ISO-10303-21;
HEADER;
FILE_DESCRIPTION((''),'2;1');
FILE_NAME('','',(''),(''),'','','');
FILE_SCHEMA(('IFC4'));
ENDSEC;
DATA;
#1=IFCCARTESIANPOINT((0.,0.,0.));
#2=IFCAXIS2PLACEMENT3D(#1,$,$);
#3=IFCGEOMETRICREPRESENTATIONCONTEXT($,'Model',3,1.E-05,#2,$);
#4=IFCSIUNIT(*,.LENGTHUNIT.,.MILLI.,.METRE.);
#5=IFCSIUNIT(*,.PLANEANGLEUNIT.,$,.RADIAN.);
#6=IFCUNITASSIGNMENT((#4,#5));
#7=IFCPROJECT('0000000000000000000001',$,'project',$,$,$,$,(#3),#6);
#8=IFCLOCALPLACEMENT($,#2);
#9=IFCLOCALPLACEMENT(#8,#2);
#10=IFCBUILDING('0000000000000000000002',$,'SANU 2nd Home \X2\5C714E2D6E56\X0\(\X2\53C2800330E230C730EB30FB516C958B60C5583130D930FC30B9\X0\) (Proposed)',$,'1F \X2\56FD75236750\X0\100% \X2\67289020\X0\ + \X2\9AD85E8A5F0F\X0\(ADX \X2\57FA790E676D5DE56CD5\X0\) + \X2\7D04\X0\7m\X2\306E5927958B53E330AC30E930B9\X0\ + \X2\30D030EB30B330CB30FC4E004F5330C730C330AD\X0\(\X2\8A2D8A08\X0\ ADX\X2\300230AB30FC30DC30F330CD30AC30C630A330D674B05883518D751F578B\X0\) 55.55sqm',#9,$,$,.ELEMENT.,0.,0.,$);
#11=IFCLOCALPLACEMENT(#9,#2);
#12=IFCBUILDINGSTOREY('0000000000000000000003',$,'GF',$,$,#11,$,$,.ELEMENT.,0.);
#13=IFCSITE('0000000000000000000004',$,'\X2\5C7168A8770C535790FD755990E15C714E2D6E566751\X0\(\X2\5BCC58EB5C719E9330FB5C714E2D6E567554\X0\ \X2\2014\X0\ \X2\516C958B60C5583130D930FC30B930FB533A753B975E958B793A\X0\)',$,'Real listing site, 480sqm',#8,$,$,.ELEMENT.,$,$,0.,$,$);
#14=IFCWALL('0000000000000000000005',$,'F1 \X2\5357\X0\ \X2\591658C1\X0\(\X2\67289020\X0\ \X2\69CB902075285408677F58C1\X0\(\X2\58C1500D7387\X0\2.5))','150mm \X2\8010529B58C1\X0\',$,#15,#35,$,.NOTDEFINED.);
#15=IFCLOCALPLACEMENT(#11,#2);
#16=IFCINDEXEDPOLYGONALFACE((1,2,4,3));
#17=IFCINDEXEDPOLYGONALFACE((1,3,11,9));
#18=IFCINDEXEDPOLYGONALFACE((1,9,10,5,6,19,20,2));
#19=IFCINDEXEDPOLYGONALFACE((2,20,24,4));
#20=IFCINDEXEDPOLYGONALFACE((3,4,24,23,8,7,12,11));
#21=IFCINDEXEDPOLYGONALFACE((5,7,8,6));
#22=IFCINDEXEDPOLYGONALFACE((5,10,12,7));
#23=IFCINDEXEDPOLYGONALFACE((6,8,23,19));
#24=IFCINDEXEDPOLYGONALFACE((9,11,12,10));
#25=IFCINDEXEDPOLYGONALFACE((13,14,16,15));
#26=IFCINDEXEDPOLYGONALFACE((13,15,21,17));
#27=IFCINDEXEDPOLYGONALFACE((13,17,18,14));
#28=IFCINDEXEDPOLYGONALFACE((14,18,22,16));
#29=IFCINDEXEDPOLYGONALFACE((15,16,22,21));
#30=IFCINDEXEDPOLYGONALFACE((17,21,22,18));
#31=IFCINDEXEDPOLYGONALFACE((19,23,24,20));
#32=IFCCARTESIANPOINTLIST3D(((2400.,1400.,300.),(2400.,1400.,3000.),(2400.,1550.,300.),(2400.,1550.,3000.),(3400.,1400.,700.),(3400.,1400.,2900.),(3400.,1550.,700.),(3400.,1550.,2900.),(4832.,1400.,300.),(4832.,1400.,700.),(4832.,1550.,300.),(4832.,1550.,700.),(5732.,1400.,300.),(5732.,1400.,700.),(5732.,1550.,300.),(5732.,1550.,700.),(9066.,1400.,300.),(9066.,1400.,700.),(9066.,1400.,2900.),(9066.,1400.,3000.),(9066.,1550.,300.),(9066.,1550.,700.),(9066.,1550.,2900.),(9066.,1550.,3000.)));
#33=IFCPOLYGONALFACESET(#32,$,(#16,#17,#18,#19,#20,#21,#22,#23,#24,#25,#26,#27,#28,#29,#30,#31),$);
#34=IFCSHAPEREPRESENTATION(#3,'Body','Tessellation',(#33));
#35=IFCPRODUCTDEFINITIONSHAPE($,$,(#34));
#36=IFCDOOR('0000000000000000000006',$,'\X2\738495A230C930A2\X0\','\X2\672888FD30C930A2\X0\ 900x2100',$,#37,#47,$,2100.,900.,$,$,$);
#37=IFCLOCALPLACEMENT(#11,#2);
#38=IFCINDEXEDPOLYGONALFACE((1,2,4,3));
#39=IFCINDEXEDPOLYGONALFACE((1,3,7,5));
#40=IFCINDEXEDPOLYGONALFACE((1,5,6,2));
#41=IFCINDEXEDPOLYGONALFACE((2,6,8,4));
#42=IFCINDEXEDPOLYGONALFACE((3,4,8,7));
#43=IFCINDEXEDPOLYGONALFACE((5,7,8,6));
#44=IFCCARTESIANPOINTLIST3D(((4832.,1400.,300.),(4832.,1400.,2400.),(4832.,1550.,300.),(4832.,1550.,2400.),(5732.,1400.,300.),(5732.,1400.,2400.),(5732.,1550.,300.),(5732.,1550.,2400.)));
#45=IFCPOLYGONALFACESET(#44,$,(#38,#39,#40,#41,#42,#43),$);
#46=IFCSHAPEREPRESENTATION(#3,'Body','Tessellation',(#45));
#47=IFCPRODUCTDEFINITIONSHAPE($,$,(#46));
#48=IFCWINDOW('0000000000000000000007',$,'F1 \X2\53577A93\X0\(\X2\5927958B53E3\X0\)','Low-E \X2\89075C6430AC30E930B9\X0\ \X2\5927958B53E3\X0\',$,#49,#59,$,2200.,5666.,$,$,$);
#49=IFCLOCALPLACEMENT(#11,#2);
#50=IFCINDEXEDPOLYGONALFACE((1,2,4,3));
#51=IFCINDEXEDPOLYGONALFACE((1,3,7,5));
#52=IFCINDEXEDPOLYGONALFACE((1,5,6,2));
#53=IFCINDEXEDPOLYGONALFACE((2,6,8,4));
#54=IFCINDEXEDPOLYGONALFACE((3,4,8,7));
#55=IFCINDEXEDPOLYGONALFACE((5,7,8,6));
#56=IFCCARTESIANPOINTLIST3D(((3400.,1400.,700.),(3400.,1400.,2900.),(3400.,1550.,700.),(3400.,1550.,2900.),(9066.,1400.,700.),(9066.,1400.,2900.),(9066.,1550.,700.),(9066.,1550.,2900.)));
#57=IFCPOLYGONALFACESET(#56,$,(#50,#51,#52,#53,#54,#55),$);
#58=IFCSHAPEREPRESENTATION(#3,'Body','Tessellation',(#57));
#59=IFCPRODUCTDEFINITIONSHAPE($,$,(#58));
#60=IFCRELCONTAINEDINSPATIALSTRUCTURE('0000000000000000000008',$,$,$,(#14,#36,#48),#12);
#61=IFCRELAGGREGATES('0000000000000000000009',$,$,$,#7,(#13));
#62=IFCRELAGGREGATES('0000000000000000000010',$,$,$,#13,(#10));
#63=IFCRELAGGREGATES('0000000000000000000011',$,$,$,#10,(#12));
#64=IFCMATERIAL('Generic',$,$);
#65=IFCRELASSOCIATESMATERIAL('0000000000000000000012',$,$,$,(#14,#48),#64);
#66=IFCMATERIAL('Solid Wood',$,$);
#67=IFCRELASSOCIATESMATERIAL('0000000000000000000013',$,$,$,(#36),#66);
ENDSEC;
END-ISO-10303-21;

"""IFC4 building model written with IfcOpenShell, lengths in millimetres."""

from ifc_helpers import new_model, si_unit, frame, frame_2d, origin, place, context, project, spatial, rectangle, extrude, material, element, fill, save


model = new_model("IFC4")

# Units and contexts
model_context = context("Model", 3, precision=1e-05, world=origin())
ifc_project = project(units=[si_unit("LENGTHUNIT", "METRE", prefix="MILLI"), si_unit("PLANEANGLEUNIT", "RADIAN")], contexts=[model_context])

# Site, building, storey
site_placement = place(None, origin())
site = spatial("IfcSite", under=ifc_project, at=site_placement, Name="山梨県南都留郡山中湖村(富士山麓・山中湖畔 — 公開情報ベース・区画非開示)", ObjectType="Real listing site, 480sqm", CompositionType="ELEMENT", RefElevation=0.0)
building_placement = place(site_placement, origin())
building = spatial("IfcBuilding", under=site, at=building_placement, Name="SANU 2nd Home 山中湖(参考モデル・公開情報ベース) (Proposed)", ObjectType="1F 国産材100% 木造 + 高床式(ADX 基礎杭工法) + 約7mの大開口ガラス + バルコニー一体デッキ(設計 ADX。カーボンネガティブ環境再生型) 55.55sqm", CompositionType="ELEMENT", ElevationOfRefHeight=0.0, ElevationOfTerrain=0.0)
storey_placement = place(building_placement, origin())
storey = spatial("IfcBuildingStorey", under=building, at=storey_placement, Name="GF", CompositionType="ELEMENT", Elevation=0.0)

# Shared definitions
ifc_material_1 = material(Name="Generic")

# Wall, openings, door, window
wall_1_placement = place(storey_placement, frame((1200.0, 700.0, 150.0)))
wall_1 = element("IfcWall", 1, at=wall_1_placement, inside=storey, material=ifc_material_1, Name="F1 南 外壁(木造 構造用合板壁(壁倍率2.5))", Description="150mm 耐力壁", PredefinedType="NOTDEFINED", context=model_context, shape_type="SweptSolid", body=[
    extrude(rectangle(XDim=6666.0, YDim=150.0, at=frame_2d((3333.0, 75.0))), frame((1200.0, 700.0, 150.0)), (0.0, 0.0, 1.0), 2700.0),
])
opening_1_placement = place(storey_placement, frame((2416.0, 700.0, 150.0)))
opening_1 = element("IfcOpeningElement", 2, at=opening_1_placement, cuts=wall_1, PredefinedType="NOTDEFINED", context=model_context, shape_type="SweptSolid", body=[
    extrude(rectangle(XDim=900.0, YDim=150.0, at=frame_2d((450.0, 75.0))), frame((2416.0, 700.0, 150.0)), (0.0, 0.0, 1.0), 2100.0),
])
opening_2_placement = place(storey_placement, frame((1700.0, 700.0, 350.0)))
opening_2 = element("IfcOpeningElement", 3, at=opening_2_placement, cuts=wall_1, PredefinedType="NOTDEFINED", context=model_context, shape_type="SweptSolid", body=[
    extrude(rectangle(XDim=5666.0, YDim=150.0, at=frame_2d((2833.0, 75.0))), frame((1700.0, 700.0, 350.0)), (0.0, 0.0, 1.0), 2200.0),
])
ifc_material_2 = material(Name="Solid Wood")
door_placement = place(storey_placement, frame((2416.0, 700.0, 150.0)))
door = element("IfcDoor", 4, at=door_placement, inside=storey, material=ifc_material_2, Name="玄関ドア", Description="木製ドア 900x2100", OverallHeight=2100.0, OverallWidth=900.0, context=model_context, shape_type="SweptSolid", body=[
    extrude(rectangle(XDim=900.0, YDim=150.0, at=frame_2d((450.0, 75.0))), frame((2416.0, 700.0, 150.0)), (0.0, 0.0, 1.0), 2100.0),
])
fill(opening_1, door)
window_1_placement = place(storey_placement, frame((1700.0, 700.0, 350.0)))
window_1 = element("IfcWindow", 5, at=window_1_placement, inside=storey, material=ifc_material_1, Name="F1 南窓(大開口)", Description="Low-E 複層ガラス 大開口", OverallHeight=2200.0, OverallWidth=5666.0, context=model_context, shape_type="SweptSolid", body=[
    extrude(rectangle(XDim=5666.0, YDim=150.0, at=frame_2d((2833.0, 75.0))), frame((1700.0, 700.0, 350.0)), (0.0, 0.0, 1.0), 2200.0),
])
fill(opening_2, window_1)

save(model, "model.ifc")
